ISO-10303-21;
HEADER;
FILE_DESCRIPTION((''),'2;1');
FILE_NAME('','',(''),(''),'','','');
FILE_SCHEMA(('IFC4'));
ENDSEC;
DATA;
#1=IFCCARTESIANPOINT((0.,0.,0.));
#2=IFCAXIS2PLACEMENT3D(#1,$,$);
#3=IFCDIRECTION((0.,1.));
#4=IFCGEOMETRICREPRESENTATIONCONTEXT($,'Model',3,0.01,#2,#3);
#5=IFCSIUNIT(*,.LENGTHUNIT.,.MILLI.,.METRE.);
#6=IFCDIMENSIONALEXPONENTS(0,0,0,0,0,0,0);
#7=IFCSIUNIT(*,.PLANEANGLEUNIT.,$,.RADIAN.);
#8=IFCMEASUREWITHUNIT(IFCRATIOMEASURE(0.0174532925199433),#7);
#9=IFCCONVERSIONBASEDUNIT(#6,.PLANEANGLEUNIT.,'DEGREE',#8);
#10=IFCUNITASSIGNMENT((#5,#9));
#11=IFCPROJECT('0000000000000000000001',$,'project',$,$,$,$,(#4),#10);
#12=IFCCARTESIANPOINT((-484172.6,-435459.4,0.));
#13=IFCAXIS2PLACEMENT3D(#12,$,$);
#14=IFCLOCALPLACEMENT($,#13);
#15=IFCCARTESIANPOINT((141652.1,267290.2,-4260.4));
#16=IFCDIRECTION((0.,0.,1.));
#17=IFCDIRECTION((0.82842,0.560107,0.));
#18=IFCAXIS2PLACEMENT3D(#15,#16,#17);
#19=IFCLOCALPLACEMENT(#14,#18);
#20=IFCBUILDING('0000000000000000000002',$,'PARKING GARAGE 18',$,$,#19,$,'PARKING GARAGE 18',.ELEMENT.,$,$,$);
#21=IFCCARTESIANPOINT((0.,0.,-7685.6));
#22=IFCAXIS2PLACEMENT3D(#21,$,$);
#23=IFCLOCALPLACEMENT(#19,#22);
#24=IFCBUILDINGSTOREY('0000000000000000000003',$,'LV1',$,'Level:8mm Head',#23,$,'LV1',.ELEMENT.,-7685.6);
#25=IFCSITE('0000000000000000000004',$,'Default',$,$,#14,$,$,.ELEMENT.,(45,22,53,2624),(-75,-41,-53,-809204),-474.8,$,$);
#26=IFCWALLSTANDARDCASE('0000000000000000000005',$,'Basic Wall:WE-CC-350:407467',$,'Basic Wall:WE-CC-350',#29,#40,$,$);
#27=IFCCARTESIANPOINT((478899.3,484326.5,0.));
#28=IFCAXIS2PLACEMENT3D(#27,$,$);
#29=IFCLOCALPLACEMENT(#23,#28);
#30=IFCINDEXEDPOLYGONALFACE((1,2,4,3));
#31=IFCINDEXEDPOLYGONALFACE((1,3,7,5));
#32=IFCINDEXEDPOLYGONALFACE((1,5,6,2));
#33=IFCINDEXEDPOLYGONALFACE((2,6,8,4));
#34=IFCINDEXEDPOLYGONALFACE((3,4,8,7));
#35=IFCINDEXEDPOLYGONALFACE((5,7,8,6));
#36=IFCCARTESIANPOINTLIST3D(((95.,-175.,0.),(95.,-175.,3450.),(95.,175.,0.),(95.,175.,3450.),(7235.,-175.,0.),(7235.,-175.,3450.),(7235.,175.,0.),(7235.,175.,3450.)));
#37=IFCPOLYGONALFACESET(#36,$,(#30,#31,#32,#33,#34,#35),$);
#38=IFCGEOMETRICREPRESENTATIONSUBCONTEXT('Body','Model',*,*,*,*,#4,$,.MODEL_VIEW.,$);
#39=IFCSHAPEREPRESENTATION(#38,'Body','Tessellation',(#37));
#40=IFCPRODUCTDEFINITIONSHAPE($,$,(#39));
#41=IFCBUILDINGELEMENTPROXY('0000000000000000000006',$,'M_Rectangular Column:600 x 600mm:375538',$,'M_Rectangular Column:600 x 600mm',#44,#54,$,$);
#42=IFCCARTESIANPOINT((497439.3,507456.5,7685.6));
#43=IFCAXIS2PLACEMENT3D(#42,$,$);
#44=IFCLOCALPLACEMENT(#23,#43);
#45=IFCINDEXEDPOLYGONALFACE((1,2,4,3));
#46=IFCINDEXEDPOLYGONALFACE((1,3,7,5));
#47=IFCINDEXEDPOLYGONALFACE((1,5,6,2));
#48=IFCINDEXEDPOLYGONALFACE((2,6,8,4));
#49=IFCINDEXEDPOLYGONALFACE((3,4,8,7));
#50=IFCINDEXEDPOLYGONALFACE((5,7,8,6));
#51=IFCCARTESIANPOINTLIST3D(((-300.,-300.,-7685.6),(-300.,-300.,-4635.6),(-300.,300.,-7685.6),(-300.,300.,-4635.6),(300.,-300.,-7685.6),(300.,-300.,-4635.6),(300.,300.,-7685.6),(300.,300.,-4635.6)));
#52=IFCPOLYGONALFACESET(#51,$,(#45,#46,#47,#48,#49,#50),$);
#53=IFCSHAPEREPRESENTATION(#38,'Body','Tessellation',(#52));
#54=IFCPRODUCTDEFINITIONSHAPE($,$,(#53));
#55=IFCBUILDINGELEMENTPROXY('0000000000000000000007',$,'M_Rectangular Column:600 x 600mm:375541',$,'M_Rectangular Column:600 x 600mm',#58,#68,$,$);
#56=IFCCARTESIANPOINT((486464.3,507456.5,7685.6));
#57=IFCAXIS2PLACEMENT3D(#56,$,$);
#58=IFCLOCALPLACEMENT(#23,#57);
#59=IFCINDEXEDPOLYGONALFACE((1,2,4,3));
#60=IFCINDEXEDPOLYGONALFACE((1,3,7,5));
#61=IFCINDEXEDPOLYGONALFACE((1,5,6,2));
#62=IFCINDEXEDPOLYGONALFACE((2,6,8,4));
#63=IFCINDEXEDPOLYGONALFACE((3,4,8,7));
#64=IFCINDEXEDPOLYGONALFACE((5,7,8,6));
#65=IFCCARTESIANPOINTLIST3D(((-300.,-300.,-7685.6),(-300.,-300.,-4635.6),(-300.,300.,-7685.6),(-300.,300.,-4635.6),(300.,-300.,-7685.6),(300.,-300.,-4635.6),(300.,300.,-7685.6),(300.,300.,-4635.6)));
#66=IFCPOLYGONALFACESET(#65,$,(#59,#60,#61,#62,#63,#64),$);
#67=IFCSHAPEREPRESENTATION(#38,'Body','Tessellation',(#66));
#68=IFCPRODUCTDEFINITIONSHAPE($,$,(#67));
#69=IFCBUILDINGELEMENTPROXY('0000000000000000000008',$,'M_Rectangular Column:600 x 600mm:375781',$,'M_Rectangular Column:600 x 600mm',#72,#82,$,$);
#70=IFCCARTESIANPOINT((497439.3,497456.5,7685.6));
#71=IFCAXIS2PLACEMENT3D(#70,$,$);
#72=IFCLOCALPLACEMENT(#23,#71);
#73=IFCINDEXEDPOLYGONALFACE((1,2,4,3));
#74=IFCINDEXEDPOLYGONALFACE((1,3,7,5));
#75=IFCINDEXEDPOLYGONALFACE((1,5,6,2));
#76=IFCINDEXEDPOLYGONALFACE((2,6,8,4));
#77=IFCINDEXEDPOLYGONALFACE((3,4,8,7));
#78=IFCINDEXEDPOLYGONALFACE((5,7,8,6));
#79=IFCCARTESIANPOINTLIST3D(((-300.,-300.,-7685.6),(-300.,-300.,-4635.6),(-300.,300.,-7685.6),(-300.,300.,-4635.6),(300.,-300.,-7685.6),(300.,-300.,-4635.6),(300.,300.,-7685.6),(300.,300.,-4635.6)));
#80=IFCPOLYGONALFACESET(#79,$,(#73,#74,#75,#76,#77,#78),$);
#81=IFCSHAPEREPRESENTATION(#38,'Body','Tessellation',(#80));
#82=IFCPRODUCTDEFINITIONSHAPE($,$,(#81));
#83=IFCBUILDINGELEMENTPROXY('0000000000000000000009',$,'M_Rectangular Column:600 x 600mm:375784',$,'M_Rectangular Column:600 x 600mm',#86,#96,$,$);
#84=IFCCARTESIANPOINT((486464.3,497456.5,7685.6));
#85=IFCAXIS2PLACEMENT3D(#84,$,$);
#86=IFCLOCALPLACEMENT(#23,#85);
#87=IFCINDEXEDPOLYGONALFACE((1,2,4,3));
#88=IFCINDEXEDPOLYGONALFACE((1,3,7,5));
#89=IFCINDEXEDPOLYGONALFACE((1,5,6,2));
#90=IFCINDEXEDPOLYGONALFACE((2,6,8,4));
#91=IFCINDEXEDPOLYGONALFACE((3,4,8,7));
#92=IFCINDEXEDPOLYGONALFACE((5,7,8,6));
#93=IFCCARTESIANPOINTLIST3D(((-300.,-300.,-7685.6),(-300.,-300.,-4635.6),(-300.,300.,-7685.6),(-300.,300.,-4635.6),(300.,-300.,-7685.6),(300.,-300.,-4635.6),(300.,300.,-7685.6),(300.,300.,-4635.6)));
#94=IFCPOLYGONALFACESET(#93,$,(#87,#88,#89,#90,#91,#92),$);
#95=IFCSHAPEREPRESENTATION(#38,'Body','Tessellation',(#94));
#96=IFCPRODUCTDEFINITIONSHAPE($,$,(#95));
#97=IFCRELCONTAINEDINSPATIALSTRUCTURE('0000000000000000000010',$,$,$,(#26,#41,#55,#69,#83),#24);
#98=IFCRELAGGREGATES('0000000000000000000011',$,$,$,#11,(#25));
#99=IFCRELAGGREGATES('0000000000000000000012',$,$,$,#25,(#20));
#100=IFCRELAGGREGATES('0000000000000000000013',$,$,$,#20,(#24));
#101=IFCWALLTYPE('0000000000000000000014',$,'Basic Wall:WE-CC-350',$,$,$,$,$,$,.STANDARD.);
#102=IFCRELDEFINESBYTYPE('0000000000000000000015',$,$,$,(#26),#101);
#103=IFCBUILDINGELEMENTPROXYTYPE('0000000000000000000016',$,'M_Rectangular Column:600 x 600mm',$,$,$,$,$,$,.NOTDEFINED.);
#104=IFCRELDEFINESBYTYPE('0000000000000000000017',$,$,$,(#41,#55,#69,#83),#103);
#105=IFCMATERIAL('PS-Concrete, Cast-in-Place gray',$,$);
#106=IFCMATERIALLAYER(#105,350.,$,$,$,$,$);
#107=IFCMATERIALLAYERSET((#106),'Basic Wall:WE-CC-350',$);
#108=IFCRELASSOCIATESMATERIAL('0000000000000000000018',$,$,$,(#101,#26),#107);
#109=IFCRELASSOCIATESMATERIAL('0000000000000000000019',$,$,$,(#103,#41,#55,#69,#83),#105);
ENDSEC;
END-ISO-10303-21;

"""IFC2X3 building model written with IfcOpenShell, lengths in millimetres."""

from ifc_helpers import new_model, entity, si_unit, converted_unit, direction, frame, frame_2d, origin, origin_2d_with_axis, place, context, subcontext, project, spatial, rectangle, extrude, source, transform, mapped, material, layer, layer_set, layer_usage, type_object, type_shapes, element, save


model = new_model("IFC2X3")

# Units and contexts
model_context = context("Model", 3, precision=0.01, world=origin(), true_north=direction((0.0, 1.0)))
body_context = subcontext(model_context, "Body", "Model", "MODEL_VIEW")
ifc_project = project(units=[si_unit("LENGTHUNIT", "METRE", prefix="MILLI"), converted_unit("PLANEANGLEUNIT", "DEGREE", entity("IfcRatioMeasure", 0.0174532925199433), si_unit("PLANEANGLEUNIT", "RADIAN"), dimensions=[0, 0, 0, 0, 0, 0, 0])], contexts=[model_context])

# Site, building, storey
site_placement = place(None, frame((-484172.6, -435459.4, 0.0)))
site = spatial("IfcSite", under=ifc_project, at=site_placement, Name="Default", CompositionType="ELEMENT", RefLatitude=(45, 22, 53, 2624), RefLongitude=(-75, -41, -53, -809204), RefElevation=-474.8)
building_placement = place(site_placement, frame((141652.1, 267290.2, -4260.4), z_axis=(0.0, 0.0, 1.0), x_axis=(0.82842, 0.560107, 0.0)))
building = spatial("IfcBuilding", under=site, at=building_placement, Name="PARKING GARAGE 18", LongName="PARKING GARAGE 18", CompositionType="ELEMENT")
storey_placement = place(building_placement, frame((0.0, 0.0, -7685.6)))
storey = spatial("IfcBuildingStorey", under=building, at=storey_placement, Name="LV1", ObjectType="Level:8mm Head", LongName="LV1", CompositionType="ELEMENT", Elevation=-7685.6)

# Shared definitions
ifc_material_1 = material(Name="PS-Concrete, Cast-in-Place gray")

# Wall
ifc_layer_1 = layer(ifc_material_1, 350.0)
ifc_layer_set_1 = layer_set([ifc_layer_1], Name="Basic Wall:WE-CC-350")
ifc_layer_usage_1 = layer_usage(ifc_layer_set_1, "AXIS2", "POSITIVE", -175.0)
wall_type_1 = type_object("IfcWallType", Name="Basic Wall:WE-CC-350", PredefinedType="STANDARD", material=ifc_layer_set_1)
wall_1_placement = place(storey_placement, frame((478899.3, 484326.5, 0.0)))
element("IfcWallStandardCase", 1, at=wall_1_placement, inside=storey, type_object=wall_type_1, material=ifc_layer_usage_1, Name="Basic Wall:WE-CC-350:407467", ObjectType="Basic Wall:WE-CC-350", context=body_context, shape_type="SweptSolid", body=[
    extrude(rectangle(XDim=7140.0, YDim=350.0, at=frame_2d((3665.0, 0.0), x_axis=(-1.0, 0.0))), origin(), (0.0, 0.0, 1.0), 3450.0),
])

# Building element proxies
building_element_proxy_type = type_object("IfcBuildingElementProxyType", Name="M_Rectangular Column:600 x 600mm", PredefinedType="NOTDEFINED", material=ifc_material_1)
shared_shape_1 = source(origin(), body_context, "Body", "SweptSolid", [
    extrude(rectangle(XDim=600.0, YDim=600.0, at=origin_2d_with_axis()), frame((0.0, 0.0, -7685.6), z_axis=(0.0, 0.0, 1.0), x_axis=(-1.0, 0.0, 0.0)), (0.0, 0.0, 1.0), 3050.0),
])
type_shapes(building_element_proxy_type, [shared_shape_1])
for number, where, name in (
    (2, (497439.3, 507456.5, 7685.6), "M_Rectangular Column:600 x 600mm:375538"),
    (3, (486464.3, 507456.5, 7685.6), "M_Rectangular Column:600 x 600mm:375541"),
    (4, (497439.3, 497456.5, 7685.6), "M_Rectangular Column:600 x 600mm:375781"),
    (5, (486464.3, 497456.5, 7685.6), "M_Rectangular Column:600 x 600mm:375784"),
):
    element("IfcBuildingElementProxy", number, at=place(storey_placement, frame(where)), inside=storey, type_object=building_element_proxy_type, material=ifc_material_1, Name=name, ObjectType="M_Rectangular Column:600 x 600mm", context=body_context, shape_type="MappedRepresentation", body=[
        mapped(shared_shape_1, transform((0.0, 0.0, 0.0), scale=1.0)),
    ])

save(model, "model.ifc")
